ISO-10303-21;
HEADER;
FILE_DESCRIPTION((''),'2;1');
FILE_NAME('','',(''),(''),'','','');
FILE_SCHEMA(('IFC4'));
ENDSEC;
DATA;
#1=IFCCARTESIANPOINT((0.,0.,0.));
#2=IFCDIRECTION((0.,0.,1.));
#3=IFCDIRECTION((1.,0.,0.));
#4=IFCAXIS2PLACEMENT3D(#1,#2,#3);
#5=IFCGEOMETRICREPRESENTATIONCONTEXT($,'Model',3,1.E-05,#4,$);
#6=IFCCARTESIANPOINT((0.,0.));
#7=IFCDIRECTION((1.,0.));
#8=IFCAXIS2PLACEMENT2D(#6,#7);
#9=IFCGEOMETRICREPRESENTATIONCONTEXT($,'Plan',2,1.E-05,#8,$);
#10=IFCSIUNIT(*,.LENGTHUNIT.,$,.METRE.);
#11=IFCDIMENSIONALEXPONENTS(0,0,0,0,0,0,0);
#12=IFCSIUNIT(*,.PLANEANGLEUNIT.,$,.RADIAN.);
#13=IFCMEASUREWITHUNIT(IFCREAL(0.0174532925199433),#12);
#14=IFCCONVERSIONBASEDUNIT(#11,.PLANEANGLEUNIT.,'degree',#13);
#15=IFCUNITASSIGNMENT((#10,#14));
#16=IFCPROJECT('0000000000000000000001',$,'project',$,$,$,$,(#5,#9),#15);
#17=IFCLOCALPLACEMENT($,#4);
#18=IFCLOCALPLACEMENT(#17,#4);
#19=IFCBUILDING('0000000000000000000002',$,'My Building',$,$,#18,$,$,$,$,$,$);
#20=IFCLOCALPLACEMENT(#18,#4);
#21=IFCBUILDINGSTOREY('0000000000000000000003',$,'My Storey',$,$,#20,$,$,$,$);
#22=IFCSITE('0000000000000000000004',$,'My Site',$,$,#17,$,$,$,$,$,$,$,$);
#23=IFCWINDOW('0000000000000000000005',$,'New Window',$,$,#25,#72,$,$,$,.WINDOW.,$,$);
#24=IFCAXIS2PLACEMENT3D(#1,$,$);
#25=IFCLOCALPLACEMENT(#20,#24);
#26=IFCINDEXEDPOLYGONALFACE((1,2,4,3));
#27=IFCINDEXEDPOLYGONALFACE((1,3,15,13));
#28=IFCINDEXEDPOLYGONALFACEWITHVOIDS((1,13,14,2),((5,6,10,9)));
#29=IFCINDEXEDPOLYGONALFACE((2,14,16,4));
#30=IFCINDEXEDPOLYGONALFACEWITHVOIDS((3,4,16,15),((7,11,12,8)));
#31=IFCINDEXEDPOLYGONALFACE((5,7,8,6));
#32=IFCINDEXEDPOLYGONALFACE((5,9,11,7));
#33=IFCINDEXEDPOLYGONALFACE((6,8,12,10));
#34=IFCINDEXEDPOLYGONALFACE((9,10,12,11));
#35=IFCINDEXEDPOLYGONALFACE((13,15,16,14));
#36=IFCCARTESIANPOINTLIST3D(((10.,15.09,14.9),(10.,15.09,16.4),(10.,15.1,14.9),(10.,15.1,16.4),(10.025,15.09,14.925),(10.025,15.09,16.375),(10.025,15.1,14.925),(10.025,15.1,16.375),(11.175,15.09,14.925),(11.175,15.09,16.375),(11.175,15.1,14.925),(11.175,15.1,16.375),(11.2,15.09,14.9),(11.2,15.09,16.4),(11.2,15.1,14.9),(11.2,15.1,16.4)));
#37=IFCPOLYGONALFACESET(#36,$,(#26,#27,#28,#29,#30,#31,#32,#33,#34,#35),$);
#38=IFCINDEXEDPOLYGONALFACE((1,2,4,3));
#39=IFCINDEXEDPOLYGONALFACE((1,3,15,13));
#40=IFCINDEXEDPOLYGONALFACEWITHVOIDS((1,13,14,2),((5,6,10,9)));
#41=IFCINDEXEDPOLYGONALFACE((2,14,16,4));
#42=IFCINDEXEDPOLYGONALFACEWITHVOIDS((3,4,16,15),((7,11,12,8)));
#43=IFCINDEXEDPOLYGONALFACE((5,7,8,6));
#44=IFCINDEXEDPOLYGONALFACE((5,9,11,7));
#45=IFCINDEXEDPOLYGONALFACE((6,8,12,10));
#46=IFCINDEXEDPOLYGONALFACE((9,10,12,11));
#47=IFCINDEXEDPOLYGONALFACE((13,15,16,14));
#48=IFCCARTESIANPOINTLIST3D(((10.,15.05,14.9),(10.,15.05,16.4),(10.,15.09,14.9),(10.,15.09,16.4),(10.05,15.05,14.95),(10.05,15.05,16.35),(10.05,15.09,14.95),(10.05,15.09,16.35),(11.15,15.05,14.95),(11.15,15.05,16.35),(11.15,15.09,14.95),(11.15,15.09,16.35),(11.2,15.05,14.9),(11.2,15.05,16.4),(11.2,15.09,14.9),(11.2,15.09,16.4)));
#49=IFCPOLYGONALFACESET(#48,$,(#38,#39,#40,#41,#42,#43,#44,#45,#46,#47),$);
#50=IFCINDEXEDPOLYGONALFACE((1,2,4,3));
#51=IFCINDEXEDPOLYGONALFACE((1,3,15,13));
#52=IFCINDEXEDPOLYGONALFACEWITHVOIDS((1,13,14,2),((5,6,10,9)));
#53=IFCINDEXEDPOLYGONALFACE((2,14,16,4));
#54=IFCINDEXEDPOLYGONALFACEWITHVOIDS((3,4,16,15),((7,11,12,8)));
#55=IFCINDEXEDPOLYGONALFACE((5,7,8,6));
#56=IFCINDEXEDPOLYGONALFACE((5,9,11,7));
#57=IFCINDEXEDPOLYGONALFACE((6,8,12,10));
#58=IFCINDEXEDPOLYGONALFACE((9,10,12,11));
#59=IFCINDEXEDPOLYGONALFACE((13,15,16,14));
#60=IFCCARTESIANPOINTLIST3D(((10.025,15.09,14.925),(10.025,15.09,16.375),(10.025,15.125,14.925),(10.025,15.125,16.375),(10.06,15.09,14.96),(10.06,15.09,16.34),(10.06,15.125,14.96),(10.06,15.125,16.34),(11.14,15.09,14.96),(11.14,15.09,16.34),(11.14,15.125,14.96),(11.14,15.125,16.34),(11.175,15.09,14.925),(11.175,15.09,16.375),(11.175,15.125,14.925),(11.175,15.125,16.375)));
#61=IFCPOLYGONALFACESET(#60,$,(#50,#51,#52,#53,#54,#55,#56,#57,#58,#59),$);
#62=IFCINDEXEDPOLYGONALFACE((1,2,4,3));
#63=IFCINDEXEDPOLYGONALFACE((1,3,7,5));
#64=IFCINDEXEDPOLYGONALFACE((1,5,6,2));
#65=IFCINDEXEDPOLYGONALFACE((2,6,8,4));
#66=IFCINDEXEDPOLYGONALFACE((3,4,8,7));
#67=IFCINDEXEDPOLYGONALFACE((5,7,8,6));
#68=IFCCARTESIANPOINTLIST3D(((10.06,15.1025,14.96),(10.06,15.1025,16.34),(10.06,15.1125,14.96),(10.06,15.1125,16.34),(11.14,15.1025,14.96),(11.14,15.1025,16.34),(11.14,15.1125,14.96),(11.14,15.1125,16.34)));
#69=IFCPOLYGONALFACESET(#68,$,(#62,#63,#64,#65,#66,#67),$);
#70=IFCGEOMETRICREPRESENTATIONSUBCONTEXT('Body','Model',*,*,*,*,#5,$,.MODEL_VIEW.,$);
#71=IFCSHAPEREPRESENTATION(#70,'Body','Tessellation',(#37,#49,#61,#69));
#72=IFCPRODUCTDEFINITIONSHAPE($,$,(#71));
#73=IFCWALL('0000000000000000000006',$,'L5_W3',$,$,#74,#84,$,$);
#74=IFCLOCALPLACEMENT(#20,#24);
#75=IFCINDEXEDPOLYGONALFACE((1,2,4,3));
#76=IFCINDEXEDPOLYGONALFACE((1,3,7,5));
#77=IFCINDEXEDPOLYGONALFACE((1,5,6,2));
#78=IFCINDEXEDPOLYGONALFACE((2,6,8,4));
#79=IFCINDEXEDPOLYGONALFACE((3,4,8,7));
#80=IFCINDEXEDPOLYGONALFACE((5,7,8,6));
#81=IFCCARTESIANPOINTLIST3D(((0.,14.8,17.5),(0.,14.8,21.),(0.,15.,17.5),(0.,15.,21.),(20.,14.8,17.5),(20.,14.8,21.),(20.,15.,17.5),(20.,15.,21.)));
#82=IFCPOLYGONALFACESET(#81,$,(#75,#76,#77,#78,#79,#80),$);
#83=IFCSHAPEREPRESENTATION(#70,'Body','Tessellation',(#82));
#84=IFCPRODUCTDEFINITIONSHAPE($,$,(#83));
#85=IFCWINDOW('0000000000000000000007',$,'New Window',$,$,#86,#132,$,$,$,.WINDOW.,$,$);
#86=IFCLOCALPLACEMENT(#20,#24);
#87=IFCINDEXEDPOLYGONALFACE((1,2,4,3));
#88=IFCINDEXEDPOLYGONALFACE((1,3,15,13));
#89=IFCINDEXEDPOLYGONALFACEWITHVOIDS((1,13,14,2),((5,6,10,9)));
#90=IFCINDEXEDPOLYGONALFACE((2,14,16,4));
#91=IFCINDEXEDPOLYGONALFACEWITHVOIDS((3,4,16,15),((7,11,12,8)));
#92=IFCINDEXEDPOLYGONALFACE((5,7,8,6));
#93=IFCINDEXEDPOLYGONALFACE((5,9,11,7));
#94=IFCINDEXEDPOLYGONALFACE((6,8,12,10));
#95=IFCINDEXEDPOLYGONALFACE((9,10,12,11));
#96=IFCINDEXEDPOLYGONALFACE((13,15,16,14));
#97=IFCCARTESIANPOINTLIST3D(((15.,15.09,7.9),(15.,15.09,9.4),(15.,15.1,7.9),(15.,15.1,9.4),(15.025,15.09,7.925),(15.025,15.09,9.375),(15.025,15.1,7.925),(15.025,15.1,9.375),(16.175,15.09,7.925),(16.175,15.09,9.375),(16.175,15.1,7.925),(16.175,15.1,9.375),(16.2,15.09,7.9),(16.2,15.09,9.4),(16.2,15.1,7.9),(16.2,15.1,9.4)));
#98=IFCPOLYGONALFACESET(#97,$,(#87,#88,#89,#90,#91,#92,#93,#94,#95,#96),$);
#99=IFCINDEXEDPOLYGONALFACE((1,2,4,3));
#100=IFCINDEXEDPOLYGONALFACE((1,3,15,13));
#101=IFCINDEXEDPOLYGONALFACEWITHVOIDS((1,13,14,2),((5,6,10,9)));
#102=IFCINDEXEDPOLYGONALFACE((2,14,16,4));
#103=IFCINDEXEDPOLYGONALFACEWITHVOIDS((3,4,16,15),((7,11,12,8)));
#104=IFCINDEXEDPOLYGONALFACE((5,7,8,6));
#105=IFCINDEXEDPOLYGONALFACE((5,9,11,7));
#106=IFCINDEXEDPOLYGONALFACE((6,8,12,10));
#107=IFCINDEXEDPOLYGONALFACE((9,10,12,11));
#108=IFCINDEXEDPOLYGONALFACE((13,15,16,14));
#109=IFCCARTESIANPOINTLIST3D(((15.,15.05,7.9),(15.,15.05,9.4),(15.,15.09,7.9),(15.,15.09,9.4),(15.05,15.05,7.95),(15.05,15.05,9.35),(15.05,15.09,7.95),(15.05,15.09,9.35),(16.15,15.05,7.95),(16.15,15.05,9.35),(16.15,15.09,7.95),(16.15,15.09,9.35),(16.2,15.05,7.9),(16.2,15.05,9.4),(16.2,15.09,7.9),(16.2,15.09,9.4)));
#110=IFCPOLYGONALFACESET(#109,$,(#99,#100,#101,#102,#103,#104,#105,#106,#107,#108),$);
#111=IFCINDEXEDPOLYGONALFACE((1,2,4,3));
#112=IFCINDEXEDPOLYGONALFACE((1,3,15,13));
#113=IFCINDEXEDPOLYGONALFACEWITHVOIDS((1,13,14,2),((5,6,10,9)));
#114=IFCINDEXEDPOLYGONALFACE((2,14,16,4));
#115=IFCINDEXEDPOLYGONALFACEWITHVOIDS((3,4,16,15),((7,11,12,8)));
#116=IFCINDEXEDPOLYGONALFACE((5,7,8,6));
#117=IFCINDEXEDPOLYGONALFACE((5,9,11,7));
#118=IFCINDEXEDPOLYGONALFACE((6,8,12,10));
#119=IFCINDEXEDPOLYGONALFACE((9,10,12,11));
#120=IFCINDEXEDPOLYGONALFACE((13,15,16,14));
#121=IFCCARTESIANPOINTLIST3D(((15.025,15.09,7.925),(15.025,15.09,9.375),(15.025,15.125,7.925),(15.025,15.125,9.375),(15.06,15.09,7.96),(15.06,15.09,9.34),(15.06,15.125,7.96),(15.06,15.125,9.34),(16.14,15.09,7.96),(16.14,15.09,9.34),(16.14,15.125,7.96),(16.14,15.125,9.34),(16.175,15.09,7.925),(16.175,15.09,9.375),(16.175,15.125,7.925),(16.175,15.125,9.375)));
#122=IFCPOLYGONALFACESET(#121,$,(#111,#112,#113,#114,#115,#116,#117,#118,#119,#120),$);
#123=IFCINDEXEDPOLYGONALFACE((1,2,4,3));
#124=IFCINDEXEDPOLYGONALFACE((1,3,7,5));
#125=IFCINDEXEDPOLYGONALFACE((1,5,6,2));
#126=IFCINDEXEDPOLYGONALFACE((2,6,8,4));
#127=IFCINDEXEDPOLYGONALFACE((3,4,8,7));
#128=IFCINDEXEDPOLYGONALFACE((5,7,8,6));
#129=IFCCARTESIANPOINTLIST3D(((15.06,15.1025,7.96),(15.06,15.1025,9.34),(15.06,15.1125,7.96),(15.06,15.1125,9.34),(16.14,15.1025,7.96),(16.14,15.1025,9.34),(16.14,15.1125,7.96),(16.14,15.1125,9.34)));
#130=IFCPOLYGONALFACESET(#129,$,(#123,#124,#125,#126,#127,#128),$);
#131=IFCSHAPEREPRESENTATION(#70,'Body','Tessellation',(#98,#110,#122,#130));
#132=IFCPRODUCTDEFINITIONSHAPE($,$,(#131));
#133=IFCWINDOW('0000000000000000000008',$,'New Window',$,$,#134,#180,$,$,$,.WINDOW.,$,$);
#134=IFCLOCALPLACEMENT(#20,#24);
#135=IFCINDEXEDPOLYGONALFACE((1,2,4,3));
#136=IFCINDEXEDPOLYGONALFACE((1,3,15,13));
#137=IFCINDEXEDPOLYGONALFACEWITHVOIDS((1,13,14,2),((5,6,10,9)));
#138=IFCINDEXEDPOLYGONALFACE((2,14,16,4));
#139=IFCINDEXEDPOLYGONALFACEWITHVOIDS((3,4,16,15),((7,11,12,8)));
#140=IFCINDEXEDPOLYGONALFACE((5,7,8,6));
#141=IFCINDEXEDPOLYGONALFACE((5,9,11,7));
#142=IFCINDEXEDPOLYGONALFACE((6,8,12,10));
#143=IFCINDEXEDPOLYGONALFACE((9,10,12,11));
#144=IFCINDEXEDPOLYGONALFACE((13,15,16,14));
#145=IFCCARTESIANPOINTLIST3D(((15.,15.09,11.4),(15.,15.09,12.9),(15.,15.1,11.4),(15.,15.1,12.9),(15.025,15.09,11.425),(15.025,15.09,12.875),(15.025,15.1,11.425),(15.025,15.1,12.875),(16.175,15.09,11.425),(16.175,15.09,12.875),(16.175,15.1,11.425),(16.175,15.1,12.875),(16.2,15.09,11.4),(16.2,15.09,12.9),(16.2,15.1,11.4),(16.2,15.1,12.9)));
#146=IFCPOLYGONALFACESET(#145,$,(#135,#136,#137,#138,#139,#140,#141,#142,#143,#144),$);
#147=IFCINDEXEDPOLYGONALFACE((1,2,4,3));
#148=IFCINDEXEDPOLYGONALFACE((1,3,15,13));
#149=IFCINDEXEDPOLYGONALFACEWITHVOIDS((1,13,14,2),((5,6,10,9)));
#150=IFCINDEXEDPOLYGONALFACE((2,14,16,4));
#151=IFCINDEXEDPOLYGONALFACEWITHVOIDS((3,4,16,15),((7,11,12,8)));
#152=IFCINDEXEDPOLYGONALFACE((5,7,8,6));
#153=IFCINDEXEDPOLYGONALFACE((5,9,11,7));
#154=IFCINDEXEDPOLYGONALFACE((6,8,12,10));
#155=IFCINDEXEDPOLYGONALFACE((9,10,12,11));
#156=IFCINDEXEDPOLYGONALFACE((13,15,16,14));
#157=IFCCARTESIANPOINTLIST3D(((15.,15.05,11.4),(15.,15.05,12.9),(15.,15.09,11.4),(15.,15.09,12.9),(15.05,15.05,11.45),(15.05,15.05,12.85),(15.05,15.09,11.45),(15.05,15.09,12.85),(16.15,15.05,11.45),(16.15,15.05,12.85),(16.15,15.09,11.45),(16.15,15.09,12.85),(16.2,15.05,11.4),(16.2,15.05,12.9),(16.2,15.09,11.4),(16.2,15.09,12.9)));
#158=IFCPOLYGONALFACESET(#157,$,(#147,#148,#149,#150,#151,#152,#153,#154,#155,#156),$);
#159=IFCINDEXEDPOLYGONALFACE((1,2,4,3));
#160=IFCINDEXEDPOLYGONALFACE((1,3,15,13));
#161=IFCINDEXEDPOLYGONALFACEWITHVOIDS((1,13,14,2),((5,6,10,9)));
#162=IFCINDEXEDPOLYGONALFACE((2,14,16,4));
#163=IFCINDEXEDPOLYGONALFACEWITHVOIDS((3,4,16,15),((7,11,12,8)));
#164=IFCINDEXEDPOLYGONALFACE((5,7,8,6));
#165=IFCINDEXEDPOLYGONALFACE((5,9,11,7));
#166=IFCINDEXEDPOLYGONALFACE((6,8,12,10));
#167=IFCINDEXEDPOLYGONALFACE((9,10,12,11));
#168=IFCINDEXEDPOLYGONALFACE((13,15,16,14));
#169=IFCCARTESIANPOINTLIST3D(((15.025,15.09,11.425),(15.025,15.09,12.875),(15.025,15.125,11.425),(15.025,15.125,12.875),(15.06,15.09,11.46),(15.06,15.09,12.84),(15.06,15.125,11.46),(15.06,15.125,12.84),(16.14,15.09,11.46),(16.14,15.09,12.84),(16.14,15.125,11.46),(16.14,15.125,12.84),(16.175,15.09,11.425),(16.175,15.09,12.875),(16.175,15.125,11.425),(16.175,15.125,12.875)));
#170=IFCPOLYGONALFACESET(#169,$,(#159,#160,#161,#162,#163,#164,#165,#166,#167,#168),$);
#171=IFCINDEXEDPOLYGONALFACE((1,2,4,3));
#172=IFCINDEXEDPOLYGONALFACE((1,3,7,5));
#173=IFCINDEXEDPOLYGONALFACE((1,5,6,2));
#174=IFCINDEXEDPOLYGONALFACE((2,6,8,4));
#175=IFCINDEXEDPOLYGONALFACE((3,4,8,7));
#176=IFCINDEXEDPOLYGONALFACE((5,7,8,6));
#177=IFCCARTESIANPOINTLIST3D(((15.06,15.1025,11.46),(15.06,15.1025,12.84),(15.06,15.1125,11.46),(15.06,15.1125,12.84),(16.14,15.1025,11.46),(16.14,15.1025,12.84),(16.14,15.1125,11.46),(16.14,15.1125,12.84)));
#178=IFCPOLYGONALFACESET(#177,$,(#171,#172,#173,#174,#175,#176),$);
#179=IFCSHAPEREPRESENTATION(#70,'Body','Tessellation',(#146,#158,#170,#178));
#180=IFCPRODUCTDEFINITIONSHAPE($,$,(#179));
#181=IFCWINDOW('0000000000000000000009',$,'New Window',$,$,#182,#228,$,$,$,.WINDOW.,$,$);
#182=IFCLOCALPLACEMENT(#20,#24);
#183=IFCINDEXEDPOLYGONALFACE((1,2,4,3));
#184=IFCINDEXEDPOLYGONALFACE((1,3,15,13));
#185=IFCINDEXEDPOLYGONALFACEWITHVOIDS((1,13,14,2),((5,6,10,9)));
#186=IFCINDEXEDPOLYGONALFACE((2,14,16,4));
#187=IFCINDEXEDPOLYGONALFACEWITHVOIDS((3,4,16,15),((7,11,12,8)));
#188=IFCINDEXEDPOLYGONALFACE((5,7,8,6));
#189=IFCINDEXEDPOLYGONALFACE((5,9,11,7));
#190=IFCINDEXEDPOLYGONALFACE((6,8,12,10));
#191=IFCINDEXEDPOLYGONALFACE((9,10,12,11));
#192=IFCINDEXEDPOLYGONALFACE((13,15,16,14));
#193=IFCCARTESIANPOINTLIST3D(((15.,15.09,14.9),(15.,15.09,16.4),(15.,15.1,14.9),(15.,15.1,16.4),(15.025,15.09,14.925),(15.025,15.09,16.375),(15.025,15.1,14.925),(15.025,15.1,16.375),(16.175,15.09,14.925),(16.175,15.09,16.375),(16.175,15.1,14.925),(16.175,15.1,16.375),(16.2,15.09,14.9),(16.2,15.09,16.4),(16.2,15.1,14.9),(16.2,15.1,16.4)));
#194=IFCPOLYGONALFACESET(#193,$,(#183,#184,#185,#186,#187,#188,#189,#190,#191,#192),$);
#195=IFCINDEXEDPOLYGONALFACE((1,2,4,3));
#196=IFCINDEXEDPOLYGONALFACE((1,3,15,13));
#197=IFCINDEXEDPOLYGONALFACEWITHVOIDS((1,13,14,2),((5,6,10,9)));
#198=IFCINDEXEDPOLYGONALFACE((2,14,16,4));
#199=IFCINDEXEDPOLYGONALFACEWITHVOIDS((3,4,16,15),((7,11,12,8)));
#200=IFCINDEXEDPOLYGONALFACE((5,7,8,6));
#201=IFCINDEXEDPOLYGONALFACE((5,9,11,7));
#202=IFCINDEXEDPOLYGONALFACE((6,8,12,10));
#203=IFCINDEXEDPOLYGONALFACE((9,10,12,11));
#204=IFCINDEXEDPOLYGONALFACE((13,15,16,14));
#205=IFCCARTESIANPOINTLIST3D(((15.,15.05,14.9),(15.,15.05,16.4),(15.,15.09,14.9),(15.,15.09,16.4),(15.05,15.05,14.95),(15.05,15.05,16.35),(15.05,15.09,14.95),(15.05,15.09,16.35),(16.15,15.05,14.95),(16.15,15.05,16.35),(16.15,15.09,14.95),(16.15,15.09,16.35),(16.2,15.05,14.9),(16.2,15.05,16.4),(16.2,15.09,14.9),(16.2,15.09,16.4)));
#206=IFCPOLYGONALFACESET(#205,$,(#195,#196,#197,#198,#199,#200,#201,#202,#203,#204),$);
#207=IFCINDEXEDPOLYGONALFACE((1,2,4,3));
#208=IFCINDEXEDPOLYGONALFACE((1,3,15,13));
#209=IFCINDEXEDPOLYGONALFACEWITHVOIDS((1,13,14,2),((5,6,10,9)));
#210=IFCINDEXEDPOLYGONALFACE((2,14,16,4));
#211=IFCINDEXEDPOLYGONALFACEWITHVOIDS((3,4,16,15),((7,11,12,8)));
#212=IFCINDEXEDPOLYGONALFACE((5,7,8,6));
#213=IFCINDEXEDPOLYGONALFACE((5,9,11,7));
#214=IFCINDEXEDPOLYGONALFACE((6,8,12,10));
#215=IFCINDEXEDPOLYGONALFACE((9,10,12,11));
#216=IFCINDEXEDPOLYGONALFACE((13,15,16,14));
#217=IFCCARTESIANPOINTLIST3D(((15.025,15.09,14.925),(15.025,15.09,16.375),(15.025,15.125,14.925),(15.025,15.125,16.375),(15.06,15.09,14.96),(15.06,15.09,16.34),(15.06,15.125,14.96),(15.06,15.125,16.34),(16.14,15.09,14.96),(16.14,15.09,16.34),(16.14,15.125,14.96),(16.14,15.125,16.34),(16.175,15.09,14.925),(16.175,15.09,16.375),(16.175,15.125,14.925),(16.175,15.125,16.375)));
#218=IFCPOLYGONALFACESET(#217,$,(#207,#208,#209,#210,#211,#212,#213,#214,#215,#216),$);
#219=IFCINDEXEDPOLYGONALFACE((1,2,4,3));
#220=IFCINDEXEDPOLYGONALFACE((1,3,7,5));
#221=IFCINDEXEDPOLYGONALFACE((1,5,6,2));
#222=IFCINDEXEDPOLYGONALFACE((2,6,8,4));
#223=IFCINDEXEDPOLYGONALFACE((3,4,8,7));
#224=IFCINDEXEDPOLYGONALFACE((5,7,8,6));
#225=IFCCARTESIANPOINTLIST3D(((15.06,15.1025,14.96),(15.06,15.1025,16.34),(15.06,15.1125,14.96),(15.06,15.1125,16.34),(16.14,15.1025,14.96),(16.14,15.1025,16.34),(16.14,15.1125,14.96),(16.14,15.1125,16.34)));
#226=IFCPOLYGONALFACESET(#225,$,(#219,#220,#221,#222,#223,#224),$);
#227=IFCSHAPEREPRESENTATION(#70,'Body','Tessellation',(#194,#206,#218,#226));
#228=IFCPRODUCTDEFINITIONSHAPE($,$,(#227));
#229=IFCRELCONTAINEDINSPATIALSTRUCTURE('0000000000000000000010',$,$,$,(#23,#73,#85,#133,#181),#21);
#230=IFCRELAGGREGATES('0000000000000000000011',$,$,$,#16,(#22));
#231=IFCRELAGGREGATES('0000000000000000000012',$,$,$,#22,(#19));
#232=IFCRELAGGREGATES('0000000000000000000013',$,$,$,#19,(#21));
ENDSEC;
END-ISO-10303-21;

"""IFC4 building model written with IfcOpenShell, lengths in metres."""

from ifc_helpers import new_model, entity, si_unit, converted_unit, frame, origin_with_axes, origin_2d_with_axis, place, context, subcontext, project, spatial, line, indexed_curve, outline, extrude, element, save


model = new_model("IFC4")

# Units and contexts
model_context = context("Model", 3, precision=1e-05, world=origin_with_axes())
plan_context = context("Plan", 2, precision=1e-05, world=origin_2d_with_axis())
body_context = subcontext(model_context, "Body", "Model", "MODEL_VIEW")
ifc_project = project(units=[si_unit("LENGTHUNIT", "METRE"), converted_unit("PLANEANGLEUNIT", "degree", entity("IfcReal", 0.0174532925199433), si_unit("PLANEANGLEUNIT", "RADIAN"), dimensions=[0, 0, 0, 0, 0, 0, 0])], contexts=[model_context, plan_context])

# Site, building, storey
site_placement = place(None, origin_with_axes())
site = spatial("IfcSite", under=ifc_project, at=site_placement, Name="My Site")
building_placement = place(site_placement, origin_with_axes())
building = spatial("IfcBuilding", under=site, at=building_placement, Name="My Building")
storey_placement = place(building_placement, origin_with_axes())
storey = spatial("IfcBuildingStorey", under=building, at=storey_placement, Name="My Storey")

# Window
for number, where, z_axis, x_axis, name in (
    (1, (10.0, 15.0, 14.9), (0.0, 0.0, 1.0), (1.0, 0.0, 0.0), "New Window"),
):
    element("IfcWindow", number, at=place(storey_placement, frame(where, z_axis=z_axis, x_axis=x_axis)), inside=storey, Name=name, PredefinedType="WINDOW", context=body_context, shape_type="SweptSolid", body=[
        extrude(outline(indexed_curve([(0.0, 0.0), (1.2, 0.0), (1.2, 1.5), (0.0, 1.5)], segments=[line(1, 2, 3, 4, 1)]), holes=[indexed_curve([(0.025, 0.025), (1.175, 0.025), (1.175, 1.475), (0.025, 1.475)], segments=[line(1, 2, 3, 4, 1)])]), frame((0.0, 0.09, 0.0), z_axis=(0.0, -1.0, 0.0), x_axis=(1.0, 0.0, 0.0)), (0.0, 0.0, -1.0), 0.01),
        extrude(outline(indexed_curve([(0.0, 0.0), (1.2, 0.0), (1.2, 1.5), (0.0, 1.5)], segments=[line(1, 2, 3, 4, 1)]), holes=[indexed_curve([(0.05, 0.05), (1.15, 0.05), (1.15, 1.45), (0.05, 1.45)], segments=[line(1, 2, 3, 4, 1)])]), frame((0.0, 0.05, 0.0), z_axis=(0.0, -1.0, 0.0), x_axis=(1.0, 0.0, 0.0)), (0.0, 0.0, -1.0), 0.04),
        extrude(outline(indexed_curve([(0.0, 0.0), (1.15, 0.0), (1.15, 1.45), (0.0, 1.45)], segments=[line(1, 2, 3, 4, 1)]), holes=[indexed_curve([(0.035, 0.035), (1.115, 0.035), (1.115, 1.415), (0.035, 1.415)], segments=[line(1, 2, 3, 4, 1)])]), frame((0.025, 0.09, 0.025), z_axis=(0.0, -1.0, 0.0), x_axis=(1.0, 0.0, 0.0)), (0.0, 0.0, -1.0), 0.035),
        extrude(outline(indexed_curve([(0.035, 0.035), (1.115, 0.035), (1.115, 1.415), (0.035, 1.415)], segments=[line(1, 2, 3, 4, 1)])), frame((0.025, 0.1025, 0.025), z_axis=(0.0, -1.0, 0.0), x_axis=(1.0, 0.0, 0.0)), (0.0, 0.0, -1.0), 0.01),
    ])

# Wall
for number, where, z_axis, x_axis, name in (
    (2, (20.0, 15.0, 17.5), (0.0, 0.0, 1.0), (-1.0, 0.0, 0.0), "L5_W3"),
):
    element("IfcWall", number, at=place(storey_placement, frame(where, z_axis=z_axis, x_axis=x_axis)), inside=storey, Name=name, context=body_context, shape_type="SweptSolid", body=[
        extrude(outline(indexed_curve([(0.0, 0.0), (0.0, 0.2), (20.0, 0.2), (20.0, 0.0), (0.0, 0.0)], self_intersect=False)), origin_with_axes(), (0.0, 0.0, 1.0), 3.5),
    ])

# Windows
for number, where, z_axis, x_axis, name in (
    (3, (15.0, 15.0, 7.9), (0.0, 0.0, 1.0), (1.0, 0.0, 0.0), "New Window"),
    (4, (15.0, 15.0, 11.4), (0.0, 0.0, 1.0), (1.0, 0.0, 0.0), "New Window"),
    (5, (15.0, 15.0, 14.9), (0.0, 0.0, 1.0), (1.0, 0.0, 0.0), "New Window"),
):
    element("IfcWindow", number, at=place(storey_placement, frame(where, z_axis=z_axis, x_axis=x_axis)), inside=storey, Name=name, PredefinedType="WINDOW", context=body_context, shape_type="SweptSolid", body=[
        extrude(outline(indexed_curve([(0.0, 0.0), (1.2, 0.0), (1.2, 1.5), (0.0, 1.5)], segments=[line(1, 2, 3, 4, 1)]), holes=[indexed_curve([(0.025, 0.025), (1.175, 0.025), (1.175, 1.475), (0.025, 1.475)], segments=[line(1, 2, 3, 4, 1)])]), frame((0.0, 0.09, 0.0), z_axis=(0.0, -1.0, 0.0), x_axis=(1.0, 0.0, 0.0)), (0.0, 0.0, -1.0), 0.01),
        extrude(outline(indexed_curve([(0.0, 0.0), (1.2, 0.0), (1.2, 1.5), (0.0, 1.5)], segments=[line(1, 2, 3, 4, 1)]), holes=[indexed_curve([(0.05, 0.05), (1.15, 0.05), (1.15, 1.45), (0.05, 1.45)], segments=[line(1, 2, 3, 4, 1)])]), frame((0.0, 0.05, 0.0), z_axis=(0.0, -1.0, 0.0), x_axis=(1.0, 0.0, 0.0)), (0.0, 0.0, -1.0), 0.04),
        extrude(outline(indexed_curve([(0.0, 0.0), (1.15, 0.0), (1.15, 1.45), (0.0, 1.45)], segments=[line(1, 2, 3, 4, 1)]), holes=[indexed_curve([(0.035, 0.035), (1.115, 0.035), (1.115, 1.415), (0.035, 1.415)], segments=[line(1, 2, 3, 4, 1)])]), frame((0.025, 0.09, 0.025), z_axis=(0.0, -1.0, 0.0), x_axis=(1.0, 0.0, 0.0)), (0.0, 0.0, -1.0), 0.035),
        extrude(outline(indexed_curve([(0.035, 0.035), (1.115, 0.035), (1.115, 1.415), (0.035, 1.415)], segments=[line(1, 2, 3, 4, 1)])), frame((0.025, 0.1025, 0.025), z_axis=(0.0, -1.0, 0.0), x_axis=(1.0, 0.0, 0.0)), (0.0, 0.0, -1.0), 0.01),
    ])

save(model, "model.ifc")
